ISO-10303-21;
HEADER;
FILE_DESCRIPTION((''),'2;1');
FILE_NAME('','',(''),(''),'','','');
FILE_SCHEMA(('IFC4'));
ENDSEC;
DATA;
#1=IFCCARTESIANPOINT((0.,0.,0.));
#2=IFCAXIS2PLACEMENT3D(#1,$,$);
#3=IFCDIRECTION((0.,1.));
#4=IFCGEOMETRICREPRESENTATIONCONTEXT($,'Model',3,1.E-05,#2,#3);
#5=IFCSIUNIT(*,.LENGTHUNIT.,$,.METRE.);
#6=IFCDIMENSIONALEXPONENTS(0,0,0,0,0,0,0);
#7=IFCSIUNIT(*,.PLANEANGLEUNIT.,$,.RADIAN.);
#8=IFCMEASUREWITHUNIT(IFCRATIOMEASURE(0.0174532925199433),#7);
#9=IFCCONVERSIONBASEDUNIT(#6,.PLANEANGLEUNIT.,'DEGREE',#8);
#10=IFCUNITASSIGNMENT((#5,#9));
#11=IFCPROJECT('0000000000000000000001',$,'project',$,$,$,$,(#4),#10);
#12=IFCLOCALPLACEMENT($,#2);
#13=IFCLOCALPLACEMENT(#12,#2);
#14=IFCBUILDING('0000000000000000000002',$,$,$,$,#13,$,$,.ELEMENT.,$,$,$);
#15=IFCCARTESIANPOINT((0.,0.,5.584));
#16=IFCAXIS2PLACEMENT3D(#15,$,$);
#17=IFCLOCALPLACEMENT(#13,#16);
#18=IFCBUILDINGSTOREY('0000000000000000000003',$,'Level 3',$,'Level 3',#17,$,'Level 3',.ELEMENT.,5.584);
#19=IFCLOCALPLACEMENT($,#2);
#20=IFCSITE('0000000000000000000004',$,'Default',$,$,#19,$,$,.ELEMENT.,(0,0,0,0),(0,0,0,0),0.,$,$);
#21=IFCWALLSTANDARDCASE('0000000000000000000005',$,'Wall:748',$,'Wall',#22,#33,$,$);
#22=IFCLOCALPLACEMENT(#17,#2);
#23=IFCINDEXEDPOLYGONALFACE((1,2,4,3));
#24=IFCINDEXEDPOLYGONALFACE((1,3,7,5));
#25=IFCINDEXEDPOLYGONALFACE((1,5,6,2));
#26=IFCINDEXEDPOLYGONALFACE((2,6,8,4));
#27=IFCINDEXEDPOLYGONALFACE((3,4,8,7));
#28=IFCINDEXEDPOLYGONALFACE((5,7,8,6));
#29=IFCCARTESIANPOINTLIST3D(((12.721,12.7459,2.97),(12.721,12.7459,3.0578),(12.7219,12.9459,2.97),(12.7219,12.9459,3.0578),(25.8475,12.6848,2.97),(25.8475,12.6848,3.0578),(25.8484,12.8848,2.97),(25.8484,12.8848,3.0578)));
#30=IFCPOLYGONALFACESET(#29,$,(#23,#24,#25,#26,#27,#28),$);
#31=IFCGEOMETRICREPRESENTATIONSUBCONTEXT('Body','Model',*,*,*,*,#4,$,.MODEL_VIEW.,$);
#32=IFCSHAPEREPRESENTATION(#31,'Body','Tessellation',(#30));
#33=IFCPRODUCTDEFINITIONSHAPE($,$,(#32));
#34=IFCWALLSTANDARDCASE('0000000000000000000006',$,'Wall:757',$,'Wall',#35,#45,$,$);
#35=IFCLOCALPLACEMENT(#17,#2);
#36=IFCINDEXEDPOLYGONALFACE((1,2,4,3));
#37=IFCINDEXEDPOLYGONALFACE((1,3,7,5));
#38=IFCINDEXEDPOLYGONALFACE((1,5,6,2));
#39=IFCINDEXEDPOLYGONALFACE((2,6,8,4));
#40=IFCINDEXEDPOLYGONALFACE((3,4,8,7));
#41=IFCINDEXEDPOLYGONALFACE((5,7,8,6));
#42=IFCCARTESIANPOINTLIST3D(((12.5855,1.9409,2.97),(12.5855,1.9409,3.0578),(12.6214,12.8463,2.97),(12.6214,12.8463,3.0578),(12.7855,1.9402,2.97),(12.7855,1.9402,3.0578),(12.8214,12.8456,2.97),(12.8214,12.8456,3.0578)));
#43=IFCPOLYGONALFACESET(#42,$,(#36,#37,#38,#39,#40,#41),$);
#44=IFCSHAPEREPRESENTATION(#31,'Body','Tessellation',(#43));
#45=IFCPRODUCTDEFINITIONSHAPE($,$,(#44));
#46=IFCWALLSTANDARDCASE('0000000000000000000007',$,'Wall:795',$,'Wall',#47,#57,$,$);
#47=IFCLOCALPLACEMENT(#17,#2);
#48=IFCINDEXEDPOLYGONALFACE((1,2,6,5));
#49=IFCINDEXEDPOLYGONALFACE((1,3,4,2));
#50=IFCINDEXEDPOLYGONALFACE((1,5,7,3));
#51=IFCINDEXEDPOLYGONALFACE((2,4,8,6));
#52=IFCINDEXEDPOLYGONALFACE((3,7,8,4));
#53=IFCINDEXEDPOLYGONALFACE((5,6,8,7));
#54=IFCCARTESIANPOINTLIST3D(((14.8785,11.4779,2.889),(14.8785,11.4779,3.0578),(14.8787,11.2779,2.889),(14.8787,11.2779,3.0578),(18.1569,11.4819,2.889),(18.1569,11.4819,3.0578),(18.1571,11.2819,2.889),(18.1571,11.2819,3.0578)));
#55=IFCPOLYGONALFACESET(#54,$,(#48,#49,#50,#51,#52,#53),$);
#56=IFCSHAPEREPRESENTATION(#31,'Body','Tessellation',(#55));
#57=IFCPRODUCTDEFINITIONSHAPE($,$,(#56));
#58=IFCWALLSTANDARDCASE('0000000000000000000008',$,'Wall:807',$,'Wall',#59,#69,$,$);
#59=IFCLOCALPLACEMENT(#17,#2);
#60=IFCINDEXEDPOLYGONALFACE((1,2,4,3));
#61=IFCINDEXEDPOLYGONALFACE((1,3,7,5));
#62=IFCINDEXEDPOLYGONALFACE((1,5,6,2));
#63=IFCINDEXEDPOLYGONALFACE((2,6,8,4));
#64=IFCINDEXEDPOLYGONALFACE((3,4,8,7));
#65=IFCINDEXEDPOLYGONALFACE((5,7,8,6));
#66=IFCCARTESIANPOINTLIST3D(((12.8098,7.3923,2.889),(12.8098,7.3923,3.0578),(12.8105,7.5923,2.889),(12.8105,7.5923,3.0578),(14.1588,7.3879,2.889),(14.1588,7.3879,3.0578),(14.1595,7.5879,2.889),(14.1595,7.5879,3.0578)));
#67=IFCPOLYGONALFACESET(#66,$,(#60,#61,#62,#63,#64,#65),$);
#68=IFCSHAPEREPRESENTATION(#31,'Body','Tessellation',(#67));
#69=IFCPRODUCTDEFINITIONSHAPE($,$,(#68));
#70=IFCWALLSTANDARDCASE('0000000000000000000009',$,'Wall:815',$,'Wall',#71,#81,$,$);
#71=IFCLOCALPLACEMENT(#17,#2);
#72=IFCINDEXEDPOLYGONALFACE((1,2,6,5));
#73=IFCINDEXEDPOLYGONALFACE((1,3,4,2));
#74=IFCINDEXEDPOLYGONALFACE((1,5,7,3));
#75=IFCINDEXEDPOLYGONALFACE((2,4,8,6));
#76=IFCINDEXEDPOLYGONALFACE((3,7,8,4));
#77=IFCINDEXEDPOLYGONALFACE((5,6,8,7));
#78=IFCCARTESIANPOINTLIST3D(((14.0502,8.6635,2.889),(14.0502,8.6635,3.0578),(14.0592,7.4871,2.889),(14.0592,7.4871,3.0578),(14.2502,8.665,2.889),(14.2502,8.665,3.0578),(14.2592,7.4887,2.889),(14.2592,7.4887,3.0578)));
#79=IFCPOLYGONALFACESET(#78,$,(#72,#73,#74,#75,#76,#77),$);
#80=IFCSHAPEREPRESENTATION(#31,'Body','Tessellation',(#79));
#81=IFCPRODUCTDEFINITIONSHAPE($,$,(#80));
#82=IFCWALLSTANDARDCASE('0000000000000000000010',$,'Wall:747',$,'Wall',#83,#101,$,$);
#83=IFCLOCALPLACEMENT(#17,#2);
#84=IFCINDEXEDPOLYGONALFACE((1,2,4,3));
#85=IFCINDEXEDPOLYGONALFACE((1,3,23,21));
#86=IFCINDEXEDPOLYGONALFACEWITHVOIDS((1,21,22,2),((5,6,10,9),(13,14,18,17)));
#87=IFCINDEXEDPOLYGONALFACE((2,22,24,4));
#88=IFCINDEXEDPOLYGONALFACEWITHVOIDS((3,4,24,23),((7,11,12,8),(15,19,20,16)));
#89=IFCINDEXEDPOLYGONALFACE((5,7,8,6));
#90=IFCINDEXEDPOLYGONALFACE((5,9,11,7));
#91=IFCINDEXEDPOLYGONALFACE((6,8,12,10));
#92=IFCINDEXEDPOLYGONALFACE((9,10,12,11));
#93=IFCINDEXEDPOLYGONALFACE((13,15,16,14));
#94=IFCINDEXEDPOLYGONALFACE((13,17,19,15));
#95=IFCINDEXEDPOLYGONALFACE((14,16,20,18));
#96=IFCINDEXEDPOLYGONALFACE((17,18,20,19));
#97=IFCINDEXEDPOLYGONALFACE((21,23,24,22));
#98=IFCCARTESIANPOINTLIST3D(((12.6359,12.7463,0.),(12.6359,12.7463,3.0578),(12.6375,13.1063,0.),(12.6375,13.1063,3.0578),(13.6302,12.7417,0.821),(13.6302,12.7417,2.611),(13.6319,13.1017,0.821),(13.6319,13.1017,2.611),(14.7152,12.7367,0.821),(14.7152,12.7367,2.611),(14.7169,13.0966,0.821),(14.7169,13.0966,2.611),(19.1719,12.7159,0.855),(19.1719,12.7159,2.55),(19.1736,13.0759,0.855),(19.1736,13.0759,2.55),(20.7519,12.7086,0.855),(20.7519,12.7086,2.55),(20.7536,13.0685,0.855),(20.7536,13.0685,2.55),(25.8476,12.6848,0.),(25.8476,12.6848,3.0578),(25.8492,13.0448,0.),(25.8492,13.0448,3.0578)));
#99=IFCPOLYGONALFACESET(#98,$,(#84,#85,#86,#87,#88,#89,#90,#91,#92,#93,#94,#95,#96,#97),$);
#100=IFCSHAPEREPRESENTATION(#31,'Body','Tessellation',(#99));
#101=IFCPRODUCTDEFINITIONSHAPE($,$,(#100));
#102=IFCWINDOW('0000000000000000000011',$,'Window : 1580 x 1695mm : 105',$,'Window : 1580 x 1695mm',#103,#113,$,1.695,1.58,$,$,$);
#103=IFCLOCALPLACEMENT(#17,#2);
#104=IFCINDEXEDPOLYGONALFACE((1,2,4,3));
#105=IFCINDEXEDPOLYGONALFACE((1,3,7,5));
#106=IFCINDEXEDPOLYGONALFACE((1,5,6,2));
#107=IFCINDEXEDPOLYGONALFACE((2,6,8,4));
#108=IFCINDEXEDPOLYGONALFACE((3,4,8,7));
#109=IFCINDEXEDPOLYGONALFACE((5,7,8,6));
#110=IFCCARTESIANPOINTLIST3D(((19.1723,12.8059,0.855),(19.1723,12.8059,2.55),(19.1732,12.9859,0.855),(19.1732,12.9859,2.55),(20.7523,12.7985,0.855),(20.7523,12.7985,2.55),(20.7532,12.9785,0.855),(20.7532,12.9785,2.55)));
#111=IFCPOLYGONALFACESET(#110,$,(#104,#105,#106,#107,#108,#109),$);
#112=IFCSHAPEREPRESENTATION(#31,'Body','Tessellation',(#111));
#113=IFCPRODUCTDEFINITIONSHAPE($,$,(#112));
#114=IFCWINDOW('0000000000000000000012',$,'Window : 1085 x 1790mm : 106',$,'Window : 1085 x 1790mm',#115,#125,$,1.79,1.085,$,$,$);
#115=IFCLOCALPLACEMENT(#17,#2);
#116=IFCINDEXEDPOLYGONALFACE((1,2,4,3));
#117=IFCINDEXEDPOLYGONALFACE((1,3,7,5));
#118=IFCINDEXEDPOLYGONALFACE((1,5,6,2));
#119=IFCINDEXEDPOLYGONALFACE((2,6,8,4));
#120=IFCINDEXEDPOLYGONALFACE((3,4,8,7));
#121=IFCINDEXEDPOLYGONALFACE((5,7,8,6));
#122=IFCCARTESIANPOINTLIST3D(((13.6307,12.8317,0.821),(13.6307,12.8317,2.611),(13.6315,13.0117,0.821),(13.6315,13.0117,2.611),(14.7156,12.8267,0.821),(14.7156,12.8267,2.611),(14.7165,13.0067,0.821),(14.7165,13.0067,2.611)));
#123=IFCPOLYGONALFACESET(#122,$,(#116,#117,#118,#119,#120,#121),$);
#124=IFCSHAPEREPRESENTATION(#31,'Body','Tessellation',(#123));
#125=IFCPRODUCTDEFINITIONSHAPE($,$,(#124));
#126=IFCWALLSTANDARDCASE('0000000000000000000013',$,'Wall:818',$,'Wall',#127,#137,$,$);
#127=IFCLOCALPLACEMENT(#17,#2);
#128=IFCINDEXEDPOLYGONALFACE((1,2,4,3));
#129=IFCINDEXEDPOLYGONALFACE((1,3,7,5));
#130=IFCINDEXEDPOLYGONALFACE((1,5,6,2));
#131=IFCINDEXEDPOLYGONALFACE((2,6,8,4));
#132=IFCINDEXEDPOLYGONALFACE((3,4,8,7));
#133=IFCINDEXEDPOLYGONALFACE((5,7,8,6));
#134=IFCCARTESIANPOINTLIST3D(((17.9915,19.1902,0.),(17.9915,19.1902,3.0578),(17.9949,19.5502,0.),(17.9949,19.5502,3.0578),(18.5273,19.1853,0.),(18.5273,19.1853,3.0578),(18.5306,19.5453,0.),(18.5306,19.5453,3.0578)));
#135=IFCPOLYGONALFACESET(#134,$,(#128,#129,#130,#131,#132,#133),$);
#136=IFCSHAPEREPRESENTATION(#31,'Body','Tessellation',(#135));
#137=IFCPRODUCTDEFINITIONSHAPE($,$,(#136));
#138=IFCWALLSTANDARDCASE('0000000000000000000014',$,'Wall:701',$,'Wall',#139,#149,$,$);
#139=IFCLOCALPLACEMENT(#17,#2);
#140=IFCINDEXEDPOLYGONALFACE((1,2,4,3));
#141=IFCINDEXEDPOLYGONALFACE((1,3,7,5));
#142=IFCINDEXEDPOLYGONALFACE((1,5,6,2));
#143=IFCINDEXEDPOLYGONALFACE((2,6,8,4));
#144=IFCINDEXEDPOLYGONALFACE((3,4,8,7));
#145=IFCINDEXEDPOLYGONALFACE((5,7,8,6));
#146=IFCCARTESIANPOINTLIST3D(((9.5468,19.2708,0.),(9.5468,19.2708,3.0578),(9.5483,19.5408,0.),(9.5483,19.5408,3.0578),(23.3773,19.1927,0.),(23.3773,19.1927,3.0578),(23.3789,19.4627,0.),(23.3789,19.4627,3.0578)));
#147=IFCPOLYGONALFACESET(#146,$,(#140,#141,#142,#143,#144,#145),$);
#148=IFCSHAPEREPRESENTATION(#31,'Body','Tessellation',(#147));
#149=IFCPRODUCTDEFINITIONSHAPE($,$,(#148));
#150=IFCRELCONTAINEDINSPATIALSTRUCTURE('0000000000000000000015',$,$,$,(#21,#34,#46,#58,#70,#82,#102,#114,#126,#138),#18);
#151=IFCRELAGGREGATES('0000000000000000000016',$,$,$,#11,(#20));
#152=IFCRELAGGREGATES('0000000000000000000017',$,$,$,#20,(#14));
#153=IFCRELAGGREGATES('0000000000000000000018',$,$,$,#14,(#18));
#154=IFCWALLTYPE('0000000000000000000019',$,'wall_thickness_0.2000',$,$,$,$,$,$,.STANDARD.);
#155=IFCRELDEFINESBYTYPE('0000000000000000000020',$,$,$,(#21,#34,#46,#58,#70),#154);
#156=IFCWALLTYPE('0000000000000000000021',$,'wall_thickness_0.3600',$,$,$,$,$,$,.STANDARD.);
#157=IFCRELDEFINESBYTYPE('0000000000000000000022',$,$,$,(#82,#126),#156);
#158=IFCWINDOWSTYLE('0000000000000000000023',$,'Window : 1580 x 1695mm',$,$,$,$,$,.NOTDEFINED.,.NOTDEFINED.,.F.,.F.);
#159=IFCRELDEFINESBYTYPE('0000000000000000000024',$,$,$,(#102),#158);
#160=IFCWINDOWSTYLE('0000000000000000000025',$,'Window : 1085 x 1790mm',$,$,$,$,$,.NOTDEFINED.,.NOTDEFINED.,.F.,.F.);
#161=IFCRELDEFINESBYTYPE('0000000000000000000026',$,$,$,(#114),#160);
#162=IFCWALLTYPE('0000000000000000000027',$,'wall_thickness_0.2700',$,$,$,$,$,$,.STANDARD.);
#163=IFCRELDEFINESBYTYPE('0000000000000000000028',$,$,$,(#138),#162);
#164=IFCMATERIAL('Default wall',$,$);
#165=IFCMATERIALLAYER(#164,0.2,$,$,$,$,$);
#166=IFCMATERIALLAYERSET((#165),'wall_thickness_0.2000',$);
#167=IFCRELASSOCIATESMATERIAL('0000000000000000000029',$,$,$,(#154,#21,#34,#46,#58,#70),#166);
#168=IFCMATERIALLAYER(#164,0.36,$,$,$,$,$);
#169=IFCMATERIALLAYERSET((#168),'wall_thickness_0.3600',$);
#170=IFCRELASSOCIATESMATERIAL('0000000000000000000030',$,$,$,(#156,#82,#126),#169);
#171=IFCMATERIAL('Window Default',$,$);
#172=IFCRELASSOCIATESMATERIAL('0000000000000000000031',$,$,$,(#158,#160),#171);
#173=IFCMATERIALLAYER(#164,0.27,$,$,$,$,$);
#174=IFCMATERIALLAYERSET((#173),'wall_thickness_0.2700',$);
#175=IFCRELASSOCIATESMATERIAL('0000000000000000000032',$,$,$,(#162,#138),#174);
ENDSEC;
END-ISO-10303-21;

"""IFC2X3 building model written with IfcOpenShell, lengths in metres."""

from ifc_helpers import new_model, entity, si_unit, converted_unit, direction, frame, frame_2d, origin, origin_2d_with_axis, place, context, subcontext, project, spatial, polyline, rectangle, outline, extrude, source, transform, mapped, material, layer, layer_set, layer_usage, type_object, type_shapes, element, fill, save


model = new_model("IFC2X3")

# Units and contexts
model_context = context("Model", 3, precision=1e-05, world=origin(), true_north=direction((0.0, 1.0)))
body_context = subcontext(model_context, "Body", "Model", "MODEL_VIEW")
ifc_project = project(units=[si_unit("LENGTHUNIT", "METRE"), converted_unit("PLANEANGLEUNIT", "DEGREE", entity("IfcRatioMeasure", 0.0174532925199433), si_unit("PLANEANGLEUNIT", "RADIAN"), dimensions=[0, 0, 0, 0, 0, 0, 0])], contexts=[model_context])

# Site, building, storey
site_placement = place(None, origin())
site = spatial("IfcSite", under=ifc_project, at=site_placement, Name="Default", CompositionType="ELEMENT", RefLatitude=(0, 0, 0, 0), RefLongitude=(0, 0, 0, 0), RefElevation=0.0)
placement_1 = place(None, origin())
building_placement = place(placement_1, origin())
building = spatial("IfcBuilding", under=site, at=building_placement, CompositionType="ELEMENT")
storey_placement = place(building_placement, frame((0.0, 0.0, 5.584)))
storey = spatial("IfcBuildingStorey", under=building, at=storey_placement, Name="Level 3", ObjectType="Level 3", LongName="Level 3", CompositionType="ELEMENT", Elevation=5.584)

# Shared definitions
ifc_material_1 = material(Name="Default wall")
ifc_material_2 = material(Name="Window Default")

# Walls
ifc_layer_1 = layer(ifc_material_1, 0.2)
ifc_layer_set_1 = layer_set([ifc_layer_1], Name="wall_thickness_0.2000")
ifc_layer_usage_1 = layer_usage(ifc_layer_set_1, "AXIS2", "POSITIVE", -0.1)
wall_type_1 = type_object("IfcWallType", Name="wall_thickness_0.2000", PredefinedType="STANDARD", material=ifc_layer_set_1)
placement_2 = place(building_placement, frame((0.0, 0.0, 8.554)))
wall_1_placement = place(placement_2, frame((12.7214, 12.8459, 0.0), z_axis=(0.0, 0.0, 1.0), x_axis=(0.999989, -0.004656, 0.0)))
element("IfcWallStandardCase", 1, at=wall_1_placement, inside=storey, type_object=wall_type_1, material=ifc_layer_usage_1, Name="Wall:748", ObjectType="Wall", context=body_context, shape_type="SweptSolid", body=[
    extrude(outline(polyline([(13.1267, -0.1), (13.1267, 0.1), (0.0, 0.1), (0.0, -0.1), (13.1267, -0.1)])), origin(), (0.0, 0.0, 1.0), 0.0878),
])
placement_3 = place(building_placement, frame((0.0, 0.0, 8.554)))
wall_2_placement = place(placement_3, frame((12.7214, 12.8459, 0.0), z_axis=(0.0, 0.0, 1.0), x_axis=(-0.003295, -0.999995, 0.0)))
element("IfcWallStandardCase", 2, at=wall_2_placement, inside=storey, type_object=wall_type_1, material=ifc_layer_usage_1, Name="Wall:757", ObjectType="Wall", context=body_context, shape_type="SweptSolid", body=[
    extrude(outline(polyline([(10.9054, -0.1), (10.9054, 0.1), (0.0, 0.1), (0.0, -0.1), (10.9054, -0.1)])), origin(), (0.0, 0.0, 1.0), 0.0878),
])
placement_4 = place(building_placement, frame((0.0, 0.0, 8.473)))
wall_3_placement = place(placement_4, frame((14.8786, 11.3779, 0.0), z_axis=(0.0, 0.0, 1.0), x_axis=(0.999999, 0.001224, 0.0)))
element("IfcWallStandardCase", 3, at=wall_3_placement, inside=storey, type_object=wall_type_1, material=ifc_layer_usage_1, Name="Wall:795", ObjectType="Wall", context=body_context, shape_type="SweptSolid", body=[
    extrude(outline(polyline([(3.2784, -0.1), (3.2784, 0.1), (0.0, 0.1), (0.0, -0.1), (3.2784, -0.1)])), origin(), (0.0, 0.0, 1.0), 0.1688),
])
placement_5 = place(building_placement, frame((0.0, 0.0, 8.473)))
wall_4_placement = place(placement_5, frame((12.8102, 7.4923, 0.0), z_axis=(0.0, 0.0, 1.0), x_axis=(0.999995, -0.003301, 0.0)))
element("IfcWallStandardCase", 4, at=wall_4_placement, inside=storey, type_object=wall_type_1, material=ifc_layer_usage_1, Name="Wall:807", ObjectType="Wall", context=body_context, shape_type="SweptSolid", body=[
    extrude(outline(polyline([(1.349, -0.1), (1.349, 0.1), (0.0, 0.1), (0.0, -0.1), (1.349, -0.1)])), origin(), (0.0, 0.0, 1.0), 0.1688),
])
placement_6 = place(building_placement, frame((0.0, 0.0, 8.473)))
wall_5_placement = place(placement_6, frame((14.1502, 8.6642, 0.0), z_axis=(0.0, 0.0, 1.0), x_axis=(0.00758, -0.999971, 0.0)))
element("IfcWallStandardCase", 5, at=wall_5_placement, inside=storey, type_object=wall_type_1, material=ifc_layer_usage_1, Name="Wall:815", ObjectType="Wall", context=body_context, shape_type="SweptSolid", body=[
    extrude(outline(polyline([(1.1764, -0.1), (1.1764, 0.1), (0.0, 0.1), (0.0, -0.1), (1.1764, -0.1)])), origin(), (0.0, 0.0, 1.0), 0.1688),
])

# Wall, openings, windows
ifc_layer_2 = layer(ifc_material_1, 0.36)
ifc_layer_set_2 = layer_set([ifc_layer_2], Name="wall_thickness_0.3600")
ifc_layer_usage_2 = layer_usage(ifc_layer_set_2, "AXIS2", "POSITIVE", -0.18)
wall_type_2 = type_object("IfcWallType", Name="wall_thickness_0.3600", PredefinedType="STANDARD", material=ifc_layer_set_2)
wall_6_placement = place(storey_placement, frame((12.6367, 12.9263, 0.0), z_axis=(0.0, 0.0, 1.0), x_axis=(0.999989, -0.004655, 0.0)))
wall_6 = element("IfcWallStandardCase", 6, at=wall_6_placement, inside=storey, type_object=wall_type_2, material=ifc_layer_usage_2, Name="Wall:747", ObjectType="Wall", context=body_context, shape_type="SweptSolid", body=[
    extrude(outline(polyline([(13.2119, -0.18), (13.2119, 0.18), (0.0, 0.18), (0.0, -0.18), (13.2119, -0.18)])), origin(), (0.0, 0.0, 1.0), 3.0578),
])
opening_1_placement = place(wall_6_placement, frame((6.5361, -0.18, 0.855)))
opening_1 = element("IfcOpeningElement", 7, at=opening_1_placement, cuts=wall_6, ObjectType="Opening", context=body_context, shape_type="SweptSolid", body=[
    extrude(rectangle(XDim=1.58, YDim=1.695, at=frame_2d((0.8475, 0.79), x_axis=(0.0, 1.0))), frame((0.0, 0.0, 0.0), z_axis=(0.0, 1.0, 0.0), x_axis=(0.0, 0.0, 1.0)), (0.0, 0.0, 1.0), 0.36),
])
opening_2_placement = place(wall_6_placement, frame((0.9944, -0.18, 0.821)))
opening_2 = element("IfcOpeningElement", 8, at=opening_2_placement, cuts=wall_6, ObjectType="Opening", context=body_context, shape_type="SweptSolid", body=[
    extrude(rectangle(XDim=1.085, YDim=1.79, at=frame_2d((0.895, 0.5425), x_axis=(0.0, 1.0))), frame((0.0, 0.0, 0.0), z_axis=(0.0, 1.0, 0.0), x_axis=(0.0, 0.0, 1.0)), (0.0, 0.0, 1.0), 0.36),
])
window_style_1 = type_object("IfcWindowStyle", Name="Window : 1580 x 1695mm", ConstructionType="NOTDEFINED", OperationType="NOTDEFINED", ParameterTakesPrecedence=False, Sizeable=False, material=ifc_material_2)
shared_shape_1 = source(origin(), body_context, "Body", "SweptSolid", [
    extrude(rectangle(XDim=0.18, YDim=1.58, at=origin_2d_with_axis()), frame((0.79, 0.18, 0.0), z_axis=(0.0, 0.0, 1.0), x_axis=(0.0, 1.0, 0.0)), (0.0, 0.0, 1.0), 1.695),
])
type_shapes(window_style_1, [shared_shape_1])
window_1_placement = place(opening_1_placement, origin())
window_1 = element("IfcWindow", 9, at=window_1_placement, inside=storey, type_object=window_style_1, Name="Window : 1580 x 1695mm : 105", ObjectType="Window : 1580 x 1695mm", OverallHeight=1.695, OverallWidth=1.58, context=body_context, shape_type="MappedRepresentation", body=[
    mapped(shared_shape_1, transform((0.0, 0.0, 0.0), scale=1.0)),
])
fill(opening_1, window_1)
window_style_2 = type_object("IfcWindowStyle", Name="Window : 1085 x 1790mm", ConstructionType="NOTDEFINED", OperationType="NOTDEFINED", ParameterTakesPrecedence=False, Sizeable=False, material=ifc_material_2)
shared_shape_2 = source(origin(), body_context, "Body", "SweptSolid", [
    extrude(rectangle(XDim=0.18, YDim=1.085, at=origin_2d_with_axis()), frame((0.5425, 0.18, 0.0), z_axis=(0.0, 0.0, 1.0), x_axis=(0.0, 1.0, 0.0)), (0.0, 0.0, 1.0), 1.79),
])
type_shapes(window_style_2, [shared_shape_2])
window_2_placement = place(opening_2_placement, origin())
window_2 = element("IfcWindow", 10, at=window_2_placement, inside=storey, type_object=window_style_2, Name="Window : 1085 x 1790mm : 106", ObjectType="Window : 1085 x 1790mm", OverallHeight=1.79, OverallWidth=1.085, context=body_context, shape_type="MappedRepresentation", body=[
    mapped(shared_shape_2, transform((0.0, 0.0, 0.0), scale=1.0)),
])
fill(opening_2, window_2)

# Walls
wall_7_placement = place(storey_placement, frame((17.9932, 19.3702, 0.0), z_axis=(0.0, 0.0, 1.0), x_axis=(0.999957, -0.009256, 0.0)))
element("IfcWallStandardCase", 11, at=wall_7_placement, inside=storey, type_object=wall_type_2, material=ifc_layer_usage_2, Name="Wall:818", ObjectType="Wall", context=body_context, shape_type="SweptSolid", body=[
    extrude(outline(polyline([(0.5358, -0.18), (0.5358, 0.18), (0.0, 0.18), (0.0, -0.18), (0.5358, -0.18)])), origin(), (0.0, 0.0, 1.0), 3.0578),
])
ifc_layer_3 = layer(ifc_material_1, 0.27)
ifc_layer_set_3 = layer_set([ifc_layer_3], Name="wall_thickness_0.2700")
ifc_layer_usage_3 = layer_usage(ifc_layer_set_3, "AXIS2", "POSITIVE", -0.135)
wall_type_3 = type_object("IfcWallType", Name="wall_thickness_0.2700", PredefinedType="STANDARD", material=ifc_layer_set_3)
wall_8_placement = place(storey_placement, frame((9.5475, 19.4058, 0.0), z_axis=(0.0, 0.0, 1.0), x_axis=(0.999984, -0.005651, 0.0)))
element("IfcWallStandardCase", 12, at=wall_8_placement, inside=storey, type_object=wall_type_3, material=ifc_layer_usage_3, Name="Wall:701", ObjectType="Wall", context=body_context, shape_type="SweptSolid", body=[
    extrude(outline(polyline([(13.8308, -0.135), (13.8308, 0.135), (0.0, 0.135), (0.0, -0.135), (13.8308, -0.135)])), origin(), (0.0, 0.0, 1.0), 3.0578),
])

save(model, "model.ifc")
